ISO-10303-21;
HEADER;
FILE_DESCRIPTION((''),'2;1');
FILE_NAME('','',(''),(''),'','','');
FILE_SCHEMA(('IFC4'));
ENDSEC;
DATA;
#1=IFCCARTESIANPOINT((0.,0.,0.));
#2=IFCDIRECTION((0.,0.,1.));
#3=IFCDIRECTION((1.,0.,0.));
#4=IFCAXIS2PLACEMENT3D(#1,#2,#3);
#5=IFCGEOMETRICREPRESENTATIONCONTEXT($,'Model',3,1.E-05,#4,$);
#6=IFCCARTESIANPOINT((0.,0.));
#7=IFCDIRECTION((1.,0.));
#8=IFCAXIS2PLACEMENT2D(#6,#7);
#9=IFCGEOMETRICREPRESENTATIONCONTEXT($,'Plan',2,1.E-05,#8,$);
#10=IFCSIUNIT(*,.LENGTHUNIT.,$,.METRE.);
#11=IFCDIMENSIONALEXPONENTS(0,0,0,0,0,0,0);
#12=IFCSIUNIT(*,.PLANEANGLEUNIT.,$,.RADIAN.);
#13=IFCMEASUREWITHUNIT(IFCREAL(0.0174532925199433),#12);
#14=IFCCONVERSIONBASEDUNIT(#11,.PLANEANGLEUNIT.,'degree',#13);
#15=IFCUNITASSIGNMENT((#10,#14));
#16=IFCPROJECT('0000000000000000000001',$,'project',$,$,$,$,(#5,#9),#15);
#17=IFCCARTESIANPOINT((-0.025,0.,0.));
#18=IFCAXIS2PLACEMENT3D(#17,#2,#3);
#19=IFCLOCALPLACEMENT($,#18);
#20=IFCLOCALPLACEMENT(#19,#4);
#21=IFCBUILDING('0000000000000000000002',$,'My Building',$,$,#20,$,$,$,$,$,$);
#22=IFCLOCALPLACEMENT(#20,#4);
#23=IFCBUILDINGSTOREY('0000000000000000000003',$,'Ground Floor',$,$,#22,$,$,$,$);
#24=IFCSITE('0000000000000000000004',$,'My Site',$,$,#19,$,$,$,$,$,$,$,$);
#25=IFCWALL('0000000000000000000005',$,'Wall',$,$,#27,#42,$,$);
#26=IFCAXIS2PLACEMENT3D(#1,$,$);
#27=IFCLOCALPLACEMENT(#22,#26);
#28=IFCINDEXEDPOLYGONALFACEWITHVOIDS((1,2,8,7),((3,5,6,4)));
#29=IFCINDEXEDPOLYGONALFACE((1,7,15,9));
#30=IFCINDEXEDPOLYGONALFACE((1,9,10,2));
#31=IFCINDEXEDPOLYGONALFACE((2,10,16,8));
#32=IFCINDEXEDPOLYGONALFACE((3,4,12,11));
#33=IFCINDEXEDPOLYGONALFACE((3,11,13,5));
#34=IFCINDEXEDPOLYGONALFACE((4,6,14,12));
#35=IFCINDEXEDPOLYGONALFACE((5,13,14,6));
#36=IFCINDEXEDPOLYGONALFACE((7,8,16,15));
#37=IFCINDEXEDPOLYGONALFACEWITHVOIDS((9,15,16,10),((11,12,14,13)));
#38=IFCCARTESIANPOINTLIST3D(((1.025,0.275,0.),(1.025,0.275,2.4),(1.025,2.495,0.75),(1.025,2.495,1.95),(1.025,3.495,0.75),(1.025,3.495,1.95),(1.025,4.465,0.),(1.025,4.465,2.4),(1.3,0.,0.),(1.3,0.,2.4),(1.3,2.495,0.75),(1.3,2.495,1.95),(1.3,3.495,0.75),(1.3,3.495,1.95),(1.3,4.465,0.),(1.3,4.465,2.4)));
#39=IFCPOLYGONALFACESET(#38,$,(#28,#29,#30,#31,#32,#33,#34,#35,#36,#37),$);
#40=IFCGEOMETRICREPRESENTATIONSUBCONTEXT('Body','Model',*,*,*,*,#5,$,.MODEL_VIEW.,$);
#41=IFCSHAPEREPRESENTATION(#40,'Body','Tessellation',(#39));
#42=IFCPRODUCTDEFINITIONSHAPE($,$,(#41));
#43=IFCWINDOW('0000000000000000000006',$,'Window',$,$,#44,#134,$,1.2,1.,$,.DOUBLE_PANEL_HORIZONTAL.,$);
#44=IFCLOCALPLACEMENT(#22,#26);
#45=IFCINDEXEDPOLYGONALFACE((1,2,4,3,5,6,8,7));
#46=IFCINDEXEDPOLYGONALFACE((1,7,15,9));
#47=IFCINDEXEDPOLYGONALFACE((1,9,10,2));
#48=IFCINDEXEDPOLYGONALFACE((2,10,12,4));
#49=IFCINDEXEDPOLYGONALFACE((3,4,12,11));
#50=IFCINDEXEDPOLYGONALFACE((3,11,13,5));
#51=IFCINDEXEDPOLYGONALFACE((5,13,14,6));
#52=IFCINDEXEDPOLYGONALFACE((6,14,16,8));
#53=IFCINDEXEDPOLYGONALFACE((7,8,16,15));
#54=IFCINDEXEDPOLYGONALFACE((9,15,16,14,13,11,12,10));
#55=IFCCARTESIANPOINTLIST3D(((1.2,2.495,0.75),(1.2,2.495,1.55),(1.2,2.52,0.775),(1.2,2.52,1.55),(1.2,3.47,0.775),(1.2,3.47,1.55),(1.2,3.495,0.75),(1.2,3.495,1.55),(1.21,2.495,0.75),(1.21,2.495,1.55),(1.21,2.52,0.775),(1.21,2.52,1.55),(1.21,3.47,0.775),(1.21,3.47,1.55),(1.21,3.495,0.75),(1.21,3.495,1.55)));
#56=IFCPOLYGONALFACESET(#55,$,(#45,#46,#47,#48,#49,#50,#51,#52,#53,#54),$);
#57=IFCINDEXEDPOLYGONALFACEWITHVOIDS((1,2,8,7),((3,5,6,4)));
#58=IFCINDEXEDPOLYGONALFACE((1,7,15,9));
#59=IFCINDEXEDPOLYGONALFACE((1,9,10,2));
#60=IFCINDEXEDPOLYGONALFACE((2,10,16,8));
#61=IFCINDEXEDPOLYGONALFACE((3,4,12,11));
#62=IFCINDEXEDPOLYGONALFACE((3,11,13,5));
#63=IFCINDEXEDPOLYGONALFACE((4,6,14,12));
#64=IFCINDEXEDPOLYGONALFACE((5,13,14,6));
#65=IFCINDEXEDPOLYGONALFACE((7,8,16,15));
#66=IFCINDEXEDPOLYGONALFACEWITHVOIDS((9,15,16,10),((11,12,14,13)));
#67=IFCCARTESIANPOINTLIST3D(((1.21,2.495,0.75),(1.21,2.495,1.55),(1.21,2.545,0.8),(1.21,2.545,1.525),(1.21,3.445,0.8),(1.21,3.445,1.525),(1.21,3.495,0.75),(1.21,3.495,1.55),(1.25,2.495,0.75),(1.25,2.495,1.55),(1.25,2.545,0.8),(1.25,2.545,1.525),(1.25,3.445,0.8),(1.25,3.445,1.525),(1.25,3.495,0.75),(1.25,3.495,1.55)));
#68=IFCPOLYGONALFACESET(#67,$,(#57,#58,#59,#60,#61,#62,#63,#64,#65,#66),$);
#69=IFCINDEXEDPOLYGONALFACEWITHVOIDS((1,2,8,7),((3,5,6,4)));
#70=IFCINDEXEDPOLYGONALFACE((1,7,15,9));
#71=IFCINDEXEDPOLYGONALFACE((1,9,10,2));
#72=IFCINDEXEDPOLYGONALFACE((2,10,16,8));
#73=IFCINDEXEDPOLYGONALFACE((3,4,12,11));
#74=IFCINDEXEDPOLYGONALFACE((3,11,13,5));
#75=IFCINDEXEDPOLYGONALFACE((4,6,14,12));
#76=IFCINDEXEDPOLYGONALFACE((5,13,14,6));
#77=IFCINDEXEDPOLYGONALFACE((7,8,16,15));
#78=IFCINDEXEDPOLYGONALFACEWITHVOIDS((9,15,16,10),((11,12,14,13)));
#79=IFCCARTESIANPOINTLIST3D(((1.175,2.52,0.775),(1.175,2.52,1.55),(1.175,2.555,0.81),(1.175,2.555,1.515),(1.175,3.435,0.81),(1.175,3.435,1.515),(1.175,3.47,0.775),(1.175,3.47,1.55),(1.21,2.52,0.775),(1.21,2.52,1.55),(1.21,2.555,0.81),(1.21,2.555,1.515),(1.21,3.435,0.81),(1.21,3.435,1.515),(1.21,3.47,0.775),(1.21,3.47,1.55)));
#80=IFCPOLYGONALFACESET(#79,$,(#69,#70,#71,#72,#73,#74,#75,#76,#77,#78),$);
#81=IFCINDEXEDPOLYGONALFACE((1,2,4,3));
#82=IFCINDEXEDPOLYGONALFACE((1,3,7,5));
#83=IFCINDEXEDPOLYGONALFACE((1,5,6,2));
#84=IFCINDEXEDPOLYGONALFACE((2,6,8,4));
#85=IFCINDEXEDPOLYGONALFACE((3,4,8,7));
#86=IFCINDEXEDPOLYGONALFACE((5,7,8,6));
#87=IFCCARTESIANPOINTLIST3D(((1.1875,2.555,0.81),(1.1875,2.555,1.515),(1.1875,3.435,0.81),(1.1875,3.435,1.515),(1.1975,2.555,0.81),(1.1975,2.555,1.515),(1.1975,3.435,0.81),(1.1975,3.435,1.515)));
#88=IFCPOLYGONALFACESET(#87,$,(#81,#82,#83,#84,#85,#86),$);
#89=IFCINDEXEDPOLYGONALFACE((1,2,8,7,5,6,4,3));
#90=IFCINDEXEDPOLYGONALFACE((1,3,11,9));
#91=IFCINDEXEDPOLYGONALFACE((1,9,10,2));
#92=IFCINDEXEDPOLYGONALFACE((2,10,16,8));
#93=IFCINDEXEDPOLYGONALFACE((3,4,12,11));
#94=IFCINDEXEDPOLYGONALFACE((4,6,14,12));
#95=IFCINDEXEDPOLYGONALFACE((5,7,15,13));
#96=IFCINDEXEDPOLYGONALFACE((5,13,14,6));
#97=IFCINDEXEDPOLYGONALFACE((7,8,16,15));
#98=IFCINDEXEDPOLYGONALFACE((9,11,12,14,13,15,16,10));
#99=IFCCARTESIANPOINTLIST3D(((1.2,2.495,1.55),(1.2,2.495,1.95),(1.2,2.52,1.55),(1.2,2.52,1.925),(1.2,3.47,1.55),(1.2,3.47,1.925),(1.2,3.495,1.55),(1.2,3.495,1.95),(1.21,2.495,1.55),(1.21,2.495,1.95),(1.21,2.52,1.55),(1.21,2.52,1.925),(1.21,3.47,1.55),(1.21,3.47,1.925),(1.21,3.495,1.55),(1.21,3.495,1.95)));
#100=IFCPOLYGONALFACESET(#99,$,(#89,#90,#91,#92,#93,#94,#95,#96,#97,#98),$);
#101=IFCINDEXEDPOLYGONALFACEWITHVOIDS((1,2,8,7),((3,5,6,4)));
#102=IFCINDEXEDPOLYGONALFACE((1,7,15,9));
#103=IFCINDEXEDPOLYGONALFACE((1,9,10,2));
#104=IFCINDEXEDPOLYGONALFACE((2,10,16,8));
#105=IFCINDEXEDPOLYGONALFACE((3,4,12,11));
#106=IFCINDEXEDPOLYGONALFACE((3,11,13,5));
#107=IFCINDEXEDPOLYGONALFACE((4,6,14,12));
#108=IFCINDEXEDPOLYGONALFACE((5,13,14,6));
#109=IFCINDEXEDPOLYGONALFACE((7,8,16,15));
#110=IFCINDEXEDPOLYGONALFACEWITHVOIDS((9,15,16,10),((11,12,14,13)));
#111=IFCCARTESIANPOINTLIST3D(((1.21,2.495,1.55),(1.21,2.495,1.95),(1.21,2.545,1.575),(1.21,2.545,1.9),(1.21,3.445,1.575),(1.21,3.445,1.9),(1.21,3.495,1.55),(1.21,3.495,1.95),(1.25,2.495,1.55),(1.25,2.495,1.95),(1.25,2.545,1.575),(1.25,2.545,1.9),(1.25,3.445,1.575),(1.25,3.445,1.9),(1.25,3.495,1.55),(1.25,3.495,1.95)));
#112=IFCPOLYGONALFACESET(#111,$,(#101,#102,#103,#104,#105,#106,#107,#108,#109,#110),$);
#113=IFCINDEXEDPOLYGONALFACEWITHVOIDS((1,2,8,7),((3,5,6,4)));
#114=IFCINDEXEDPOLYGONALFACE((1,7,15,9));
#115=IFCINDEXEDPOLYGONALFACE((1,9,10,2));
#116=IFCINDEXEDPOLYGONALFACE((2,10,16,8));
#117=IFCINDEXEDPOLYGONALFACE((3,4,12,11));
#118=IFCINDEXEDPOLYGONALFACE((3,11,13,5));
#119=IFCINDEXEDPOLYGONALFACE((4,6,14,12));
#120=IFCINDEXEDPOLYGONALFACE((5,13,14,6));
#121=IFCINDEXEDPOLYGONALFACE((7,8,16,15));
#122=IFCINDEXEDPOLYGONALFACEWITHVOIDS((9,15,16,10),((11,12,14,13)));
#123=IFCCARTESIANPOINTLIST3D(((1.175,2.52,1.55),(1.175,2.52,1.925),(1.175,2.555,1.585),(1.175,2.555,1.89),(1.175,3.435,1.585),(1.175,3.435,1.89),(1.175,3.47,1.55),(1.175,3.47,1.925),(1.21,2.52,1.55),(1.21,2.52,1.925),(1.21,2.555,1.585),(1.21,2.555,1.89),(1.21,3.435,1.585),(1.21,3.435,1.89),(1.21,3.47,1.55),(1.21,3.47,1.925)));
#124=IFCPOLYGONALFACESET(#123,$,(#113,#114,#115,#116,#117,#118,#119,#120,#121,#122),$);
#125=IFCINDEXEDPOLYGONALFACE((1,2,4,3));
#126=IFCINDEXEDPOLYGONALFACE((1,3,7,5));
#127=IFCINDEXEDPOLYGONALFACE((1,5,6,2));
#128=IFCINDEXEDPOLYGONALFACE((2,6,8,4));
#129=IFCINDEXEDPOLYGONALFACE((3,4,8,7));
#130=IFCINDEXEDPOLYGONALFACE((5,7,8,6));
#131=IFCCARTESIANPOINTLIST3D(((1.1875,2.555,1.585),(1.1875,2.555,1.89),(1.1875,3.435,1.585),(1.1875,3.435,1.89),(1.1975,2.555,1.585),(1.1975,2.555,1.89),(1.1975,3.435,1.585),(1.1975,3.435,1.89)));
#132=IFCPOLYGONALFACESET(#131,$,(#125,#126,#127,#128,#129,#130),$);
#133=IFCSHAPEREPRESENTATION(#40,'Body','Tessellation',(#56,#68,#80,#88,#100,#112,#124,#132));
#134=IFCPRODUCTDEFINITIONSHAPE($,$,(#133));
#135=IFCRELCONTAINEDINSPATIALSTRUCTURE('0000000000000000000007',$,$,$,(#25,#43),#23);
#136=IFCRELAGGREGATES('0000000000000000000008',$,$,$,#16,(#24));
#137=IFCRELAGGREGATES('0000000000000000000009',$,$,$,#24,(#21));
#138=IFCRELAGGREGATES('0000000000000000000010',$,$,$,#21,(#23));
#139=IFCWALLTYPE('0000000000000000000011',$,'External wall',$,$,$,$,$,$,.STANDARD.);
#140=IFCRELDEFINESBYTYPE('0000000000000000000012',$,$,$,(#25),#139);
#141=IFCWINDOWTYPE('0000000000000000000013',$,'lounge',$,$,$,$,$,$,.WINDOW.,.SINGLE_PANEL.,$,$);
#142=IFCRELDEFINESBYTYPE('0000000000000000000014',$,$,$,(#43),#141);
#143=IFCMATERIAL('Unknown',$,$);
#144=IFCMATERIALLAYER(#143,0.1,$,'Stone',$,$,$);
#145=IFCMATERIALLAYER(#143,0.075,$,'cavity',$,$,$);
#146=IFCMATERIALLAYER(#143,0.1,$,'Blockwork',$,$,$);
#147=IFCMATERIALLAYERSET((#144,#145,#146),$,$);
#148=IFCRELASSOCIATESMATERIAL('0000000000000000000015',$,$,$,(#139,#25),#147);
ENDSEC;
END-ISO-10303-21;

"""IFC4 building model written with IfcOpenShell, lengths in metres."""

from ifc_helpers import new_model, entity, si_unit, converted_unit, frame, origin_with_axes, origin_2d_with_axis, place, context, subcontext, project, spatial, line, indexed_curve, outline, extrude, clip, halfspace, shape, source, transform, mapped, material, layer, layer_set, layer_usage, type_object, type_shapes, element, fill, save


model = new_model("IFC4")

# Units and contexts
model_context = context("Model", 3, precision=1e-05, world=origin_with_axes())
plan_context = context("Plan", 2, precision=1e-05, world=origin_2d_with_axis())
body_context_1 = subcontext(model_context, "Body", "Model", "MODEL_VIEW")
body_context_2 = subcontext(plan_context, "Body", "Plan", "PLAN_VIEW")
ifc_project = project(units=[si_unit("LENGTHUNIT", "METRE"), converted_unit("PLANEANGLEUNIT", "degree", entity("IfcReal", 0.0174532925199433), si_unit("PLANEANGLEUNIT", "RADIAN"), dimensions=[0, 0, 0, 0, 0, 0, 0])], contexts=[model_context, plan_context])

# Site, building, storey
site_placement = place(None, frame((-0.025, 0.0, 0.0), z_axis=(0.0, 0.0, 1.0), x_axis=(1.0, 0.0, 0.0)))
site = spatial("IfcSite", under=ifc_project, at=site_placement, Name="My Site")
building_placement = place(site_placement, origin_with_axes())
building = spatial("IfcBuilding", under=site, at=building_placement, Name="My Building")
storey_placement = place(building_placement, frame((0.0, 0.0, 0.0), z_axis=(0.0, 0.0, 1.0), x_axis=(1.0, 0.0, 0.0)))
storey = spatial("IfcBuildingStorey", under=building, at=storey_placement, Name="Ground Floor")

# Shared definitions
ifc_material = material(Name="Unknown")
ifc_layer_1 = layer(ifc_material, 0.1, Name="Stone")
ifc_layer_2 = layer(ifc_material, 0.075, Name="cavity")
ifc_layer_3 = layer(ifc_material, 0.1, Name="Blockwork")
ifc_layer_set_1 = layer_set([ifc_layer_1, ifc_layer_2, ifc_layer_3])
wall_type_1 = type_object("IfcWallType", Name="External wall", PredefinedType="STANDARD", material=ifc_layer_set_1)

# Wall, opening, window
ifc_layer_usage_1 = layer_usage(ifc_layer_set_1, "AXIS2", "POSITIVE", 0.0)
wall_1_placement = place(storey_placement, frame((1.3, 0.0, 0.0), z_axis=(0.0, 0.0, 1.0), x_axis=(0.0, 1.0, 0.0)))
wall_1 = element("IfcWall", 1, at=wall_1_placement, inside=storey, type_object=wall_type_1, material=ifc_layer_usage_1, Name="Wall", context=body_context_1, shape_type="Clipping", body=[
    clip(extrude(outline(indexed_curve([(0.0, 0.0), (0.0, 0.275), (4.465, 0.275), (4.465, 0.0), (0.0, 0.0)], self_intersect=False)), origin_with_axes(), (0.0, 0.0, 1.0), 2.4), halfspace(frame((0.0, 0.0, 0.0), z_axis=(-0.707107, 0.707107, 0.0), x_axis=(0.707107, 0.707107, 0.0)), False)),
])
shared_shape_1 = source(origin_with_axes(), body_context_1, "Body", "SweptSolid", [
    extrude(outline(indexed_curve([(0.0, 0.0), (1.0, 0.0), (1.0, 1.2), (0.0, 1.2)], segments=[line(1, 2, 3, 4, 1)])), frame((0.0, -0.1, 0.0), z_axis=(0.0, -1.0, 0.0), x_axis=(1.0, 0.0, 0.0)), (0.0, 0.0, -1.0), 0.475),
])
opening_1_placement = place(wall_1_placement, frame((2.495, 0.0, 0.75), z_axis=(0.0, 0.0, 1.0), x_axis=(1.0, 0.0, 0.0)))
opening_1 = element("IfcOpeningElement", 2, at=opening_1_placement, cuts=wall_1, PredefinedType="OPENING", context=body_context_1, shape_type="MappedRepresentation", body=[
    mapped(shared_shape_1, transform((0.0, 0.0, 0.0), x_axis=(1.0, 0.0, 0.0), y_axis=(0.0, 1.0, 0.0), z_axis=(0.0, 0.0, 1.0), scale=1.0)),
])
window_type_1 = type_object("IfcWindowType", Name="lounge", PartitioningType="SINGLE_PANEL", PredefinedType="WINDOW")
shared_shape_2 = source(origin_with_axes(), body_context_1, "Body", "SweptSolid", [
    extrude(outline(indexed_curve([(1.0, 0.8), (1.0, 0.0), (0.0, 0.0), (0.0, 0.8), (0.025, 0.8), (0.025, 0.025), (0.975, 0.025), (0.975, 0.8)], segments=[line(1, 2, 3, 4, 5, 6, 7, 8, 1)])), frame((0.0, 0.09, 0.0), z_axis=(0.0, -1.0, 0.0), x_axis=(1.0, 0.0, 0.0)), (0.0, 0.0, -1.0), 0.01),
    extrude(outline(indexed_curve([(0.0, 0.0), (1.0, 0.0), (1.0, 0.8), (0.0, 0.8)], segments=[line(1, 2, 3, 4, 1)]), holes=[indexed_curve([(0.05, 0.05), (0.95, 0.05), (0.95, 0.775), (0.05, 0.775)], segments=[line(1, 2, 3, 4, 1)])]), frame((0.0, 0.05, 0.0), z_axis=(0.0, -1.0, 0.0), x_axis=(1.0, 0.0, 0.0)), (0.0, 0.0, -1.0), 0.04),
    extrude(outline(indexed_curve([(0.0, 0.0), (0.95, 0.0), (0.95, 0.775), (0.0, 0.775)], segments=[line(1, 2, 3, 4, 1)]), holes=[indexed_curve([(0.035, 0.035), (0.915, 0.035), (0.915, 0.74), (0.035, 0.74)], segments=[line(1, 2, 3, 4, 1)])]), frame((0.025, 0.09, 0.025), z_axis=(0.0, -1.0, 0.0), x_axis=(1.0, 0.0, 0.0)), (0.0, 0.0, -1.0), 0.035),
    extrude(outline(indexed_curve([(0.035, 0.035), (0.915, 0.035), (0.915, 0.74), (0.035, 0.74)], segments=[line(1, 2, 3, 4, 1)])), frame((0.025, 0.1025, 0.025), z_axis=(0.0, -1.0, 0.0), x_axis=(1.0, 0.0, 0.0)), (0.0, 0.0, -1.0), 0.01),
    extrude(outline(indexed_curve([(0.0, 0.0), (0.0, 0.4), (1.0, 0.4), (1.0, 0.0), (0.975, 0.0), (0.975, 0.375), (0.025, 0.375), (0.025, 0.0)], segments=[line(1, 2, 3, 4, 5, 6, 7, 8, 1)])), frame((0.0, 0.09, 0.8), z_axis=(0.0, -1.0, 0.0), x_axis=(1.0, 0.0, 0.0)), (0.0, 0.0, -1.0), 0.01),
    extrude(outline(indexed_curve([(0.0, 0.0), (1.0, 0.0), (1.0, 0.4), (0.0, 0.4)], segments=[line(1, 2, 3, 4, 1)]), holes=[indexed_curve([(0.05, 0.025), (0.95, 0.025), (0.95, 0.35), (0.05, 0.35)], segments=[line(1, 2, 3, 4, 1)])]), frame((0.0, 0.05, 0.8), z_axis=(0.0, -1.0, 0.0), x_axis=(1.0, 0.0, 0.0)), (0.0, 0.0, -1.0), 0.04),
    extrude(outline(indexed_curve([(0.0, 0.0), (0.95, 0.0), (0.95, 0.375), (0.0, 0.375)], segments=[line(1, 2, 3, 4, 1)]), holes=[indexed_curve([(0.035, 0.035), (0.915, 0.035), (0.915, 0.34), (0.035, 0.34)], segments=[line(1, 2, 3, 4, 1)])]), frame((0.025, 0.09, 0.8), z_axis=(0.0, -1.0, 0.0), x_axis=(1.0, 0.0, 0.0)), (0.0, 0.0, -1.0), 0.035),
    extrude(outline(indexed_curve([(0.035, 0.035), (0.915, 0.035), (0.915, 0.34), (0.035, 0.34)], segments=[line(1, 2, 3, 4, 1)])), frame((0.025, 0.1025, 0.8), z_axis=(0.0, -1.0, 0.0), x_axis=(1.0, 0.0, 0.0)), (0.0, 0.0, -1.0), 0.01),
])
shared_shape_3 = source(origin_with_axes(), body_context_2, "Body", "Curve2D", [
    entity("IfcIndexedPolyCurve", entity("IfcCartesianPointList2D", [[0.05, 0.05], [0.95, 0.05]])),
    entity("IfcIndexedPolyCurve", entity("IfcCartesianPointList2D", [[0.0, 0.1], [0.025, 0.1], [0.025, 0.09], [0.05, 0.09], [0.05, 0.05], [0.0, 0.05]]), [entity("IfcLineIndex", [1, 2, 3, 4, 5, 6, 1])]),
    entity("IfcIndexedPolyCurve", entity("IfcCartesianPointList2D", [[1.0, 0.1], [0.975, 0.1], [0.975, 0.09], [0.95, 0.09], [0.95, 0.05], [1.0, 0.05]]), [entity("IfcLineIndex", [1, 2, 3, 4, 5, 6, 1])]),
    entity("IfcIndexedPolyCurve", entity("IfcCartesianPointList2D", [[0.025, 0.09], [0.06, 0.09], [0.06, 0.125], [0.025, 0.125]]), [entity("IfcLineIndex", [1, 2, 3, 4, 1])]),
    entity("IfcIndexedPolyCurve", entity("IfcCartesianPointList2D", [[0.975, 0.09], [0.94, 0.09], [0.94, 0.125], [0.975, 0.125]]), [entity("IfcLineIndex", [1, 2, 3, 4, 1])]),
    entity("IfcIndexedPolyCurve", entity("IfcCartesianPointList2D", [[0.06, 0.09], [0.94, 0.09]])),
    entity("IfcIndexedPolyCurve", entity("IfcCartesianPointList2D", [[0.06, 0.125], [0.94, 0.125]])),
    entity("IfcIndexedPolyCurve", entity("IfcCartesianPointList2D", [[0.06, 0.1075], [0.94, 0.1075]])),
])
type_shapes(window_type_1, [shared_shape_2, shared_shape_3])
window_1_placement = place(opening_1_placement, frame((0.0, 0.0, 0.0), z_axis=(0.0, 0.0, 1.0), x_axis=(1.0, 0.0, 0.0)))
window_1 = element("IfcWindow", 3, at=window_1_placement, inside=storey, type_object=window_type_1, Name="Window", OverallHeight=1.2, OverallWidth=1.0, PartitioningType="DOUBLE_PANEL_HORIZONTAL", shapes=[
    shape(body_context_1, "Body", "MappedRepresentation", [mapped(shared_shape_2, transform((0.0, 0.0, 0.0), x_axis=(1.0, 0.0, 0.0), y_axis=(0.0, 1.0, 0.0), z_axis=(0.0, 0.0, 1.0), scale=1.0))]),
    shape(body_context_2, "Body", "MappedRepresentation", [mapped(shared_shape_3, transform((0.0, 0.0, 0.0), x_axis=(1.0, 0.0, 0.0), y_axis=(0.0, 1.0, 0.0), z_axis=(0.0, 0.0, 1.0), scale=1.0))]),
])
fill(opening_1, window_1)

save(model, "model.ifc")
